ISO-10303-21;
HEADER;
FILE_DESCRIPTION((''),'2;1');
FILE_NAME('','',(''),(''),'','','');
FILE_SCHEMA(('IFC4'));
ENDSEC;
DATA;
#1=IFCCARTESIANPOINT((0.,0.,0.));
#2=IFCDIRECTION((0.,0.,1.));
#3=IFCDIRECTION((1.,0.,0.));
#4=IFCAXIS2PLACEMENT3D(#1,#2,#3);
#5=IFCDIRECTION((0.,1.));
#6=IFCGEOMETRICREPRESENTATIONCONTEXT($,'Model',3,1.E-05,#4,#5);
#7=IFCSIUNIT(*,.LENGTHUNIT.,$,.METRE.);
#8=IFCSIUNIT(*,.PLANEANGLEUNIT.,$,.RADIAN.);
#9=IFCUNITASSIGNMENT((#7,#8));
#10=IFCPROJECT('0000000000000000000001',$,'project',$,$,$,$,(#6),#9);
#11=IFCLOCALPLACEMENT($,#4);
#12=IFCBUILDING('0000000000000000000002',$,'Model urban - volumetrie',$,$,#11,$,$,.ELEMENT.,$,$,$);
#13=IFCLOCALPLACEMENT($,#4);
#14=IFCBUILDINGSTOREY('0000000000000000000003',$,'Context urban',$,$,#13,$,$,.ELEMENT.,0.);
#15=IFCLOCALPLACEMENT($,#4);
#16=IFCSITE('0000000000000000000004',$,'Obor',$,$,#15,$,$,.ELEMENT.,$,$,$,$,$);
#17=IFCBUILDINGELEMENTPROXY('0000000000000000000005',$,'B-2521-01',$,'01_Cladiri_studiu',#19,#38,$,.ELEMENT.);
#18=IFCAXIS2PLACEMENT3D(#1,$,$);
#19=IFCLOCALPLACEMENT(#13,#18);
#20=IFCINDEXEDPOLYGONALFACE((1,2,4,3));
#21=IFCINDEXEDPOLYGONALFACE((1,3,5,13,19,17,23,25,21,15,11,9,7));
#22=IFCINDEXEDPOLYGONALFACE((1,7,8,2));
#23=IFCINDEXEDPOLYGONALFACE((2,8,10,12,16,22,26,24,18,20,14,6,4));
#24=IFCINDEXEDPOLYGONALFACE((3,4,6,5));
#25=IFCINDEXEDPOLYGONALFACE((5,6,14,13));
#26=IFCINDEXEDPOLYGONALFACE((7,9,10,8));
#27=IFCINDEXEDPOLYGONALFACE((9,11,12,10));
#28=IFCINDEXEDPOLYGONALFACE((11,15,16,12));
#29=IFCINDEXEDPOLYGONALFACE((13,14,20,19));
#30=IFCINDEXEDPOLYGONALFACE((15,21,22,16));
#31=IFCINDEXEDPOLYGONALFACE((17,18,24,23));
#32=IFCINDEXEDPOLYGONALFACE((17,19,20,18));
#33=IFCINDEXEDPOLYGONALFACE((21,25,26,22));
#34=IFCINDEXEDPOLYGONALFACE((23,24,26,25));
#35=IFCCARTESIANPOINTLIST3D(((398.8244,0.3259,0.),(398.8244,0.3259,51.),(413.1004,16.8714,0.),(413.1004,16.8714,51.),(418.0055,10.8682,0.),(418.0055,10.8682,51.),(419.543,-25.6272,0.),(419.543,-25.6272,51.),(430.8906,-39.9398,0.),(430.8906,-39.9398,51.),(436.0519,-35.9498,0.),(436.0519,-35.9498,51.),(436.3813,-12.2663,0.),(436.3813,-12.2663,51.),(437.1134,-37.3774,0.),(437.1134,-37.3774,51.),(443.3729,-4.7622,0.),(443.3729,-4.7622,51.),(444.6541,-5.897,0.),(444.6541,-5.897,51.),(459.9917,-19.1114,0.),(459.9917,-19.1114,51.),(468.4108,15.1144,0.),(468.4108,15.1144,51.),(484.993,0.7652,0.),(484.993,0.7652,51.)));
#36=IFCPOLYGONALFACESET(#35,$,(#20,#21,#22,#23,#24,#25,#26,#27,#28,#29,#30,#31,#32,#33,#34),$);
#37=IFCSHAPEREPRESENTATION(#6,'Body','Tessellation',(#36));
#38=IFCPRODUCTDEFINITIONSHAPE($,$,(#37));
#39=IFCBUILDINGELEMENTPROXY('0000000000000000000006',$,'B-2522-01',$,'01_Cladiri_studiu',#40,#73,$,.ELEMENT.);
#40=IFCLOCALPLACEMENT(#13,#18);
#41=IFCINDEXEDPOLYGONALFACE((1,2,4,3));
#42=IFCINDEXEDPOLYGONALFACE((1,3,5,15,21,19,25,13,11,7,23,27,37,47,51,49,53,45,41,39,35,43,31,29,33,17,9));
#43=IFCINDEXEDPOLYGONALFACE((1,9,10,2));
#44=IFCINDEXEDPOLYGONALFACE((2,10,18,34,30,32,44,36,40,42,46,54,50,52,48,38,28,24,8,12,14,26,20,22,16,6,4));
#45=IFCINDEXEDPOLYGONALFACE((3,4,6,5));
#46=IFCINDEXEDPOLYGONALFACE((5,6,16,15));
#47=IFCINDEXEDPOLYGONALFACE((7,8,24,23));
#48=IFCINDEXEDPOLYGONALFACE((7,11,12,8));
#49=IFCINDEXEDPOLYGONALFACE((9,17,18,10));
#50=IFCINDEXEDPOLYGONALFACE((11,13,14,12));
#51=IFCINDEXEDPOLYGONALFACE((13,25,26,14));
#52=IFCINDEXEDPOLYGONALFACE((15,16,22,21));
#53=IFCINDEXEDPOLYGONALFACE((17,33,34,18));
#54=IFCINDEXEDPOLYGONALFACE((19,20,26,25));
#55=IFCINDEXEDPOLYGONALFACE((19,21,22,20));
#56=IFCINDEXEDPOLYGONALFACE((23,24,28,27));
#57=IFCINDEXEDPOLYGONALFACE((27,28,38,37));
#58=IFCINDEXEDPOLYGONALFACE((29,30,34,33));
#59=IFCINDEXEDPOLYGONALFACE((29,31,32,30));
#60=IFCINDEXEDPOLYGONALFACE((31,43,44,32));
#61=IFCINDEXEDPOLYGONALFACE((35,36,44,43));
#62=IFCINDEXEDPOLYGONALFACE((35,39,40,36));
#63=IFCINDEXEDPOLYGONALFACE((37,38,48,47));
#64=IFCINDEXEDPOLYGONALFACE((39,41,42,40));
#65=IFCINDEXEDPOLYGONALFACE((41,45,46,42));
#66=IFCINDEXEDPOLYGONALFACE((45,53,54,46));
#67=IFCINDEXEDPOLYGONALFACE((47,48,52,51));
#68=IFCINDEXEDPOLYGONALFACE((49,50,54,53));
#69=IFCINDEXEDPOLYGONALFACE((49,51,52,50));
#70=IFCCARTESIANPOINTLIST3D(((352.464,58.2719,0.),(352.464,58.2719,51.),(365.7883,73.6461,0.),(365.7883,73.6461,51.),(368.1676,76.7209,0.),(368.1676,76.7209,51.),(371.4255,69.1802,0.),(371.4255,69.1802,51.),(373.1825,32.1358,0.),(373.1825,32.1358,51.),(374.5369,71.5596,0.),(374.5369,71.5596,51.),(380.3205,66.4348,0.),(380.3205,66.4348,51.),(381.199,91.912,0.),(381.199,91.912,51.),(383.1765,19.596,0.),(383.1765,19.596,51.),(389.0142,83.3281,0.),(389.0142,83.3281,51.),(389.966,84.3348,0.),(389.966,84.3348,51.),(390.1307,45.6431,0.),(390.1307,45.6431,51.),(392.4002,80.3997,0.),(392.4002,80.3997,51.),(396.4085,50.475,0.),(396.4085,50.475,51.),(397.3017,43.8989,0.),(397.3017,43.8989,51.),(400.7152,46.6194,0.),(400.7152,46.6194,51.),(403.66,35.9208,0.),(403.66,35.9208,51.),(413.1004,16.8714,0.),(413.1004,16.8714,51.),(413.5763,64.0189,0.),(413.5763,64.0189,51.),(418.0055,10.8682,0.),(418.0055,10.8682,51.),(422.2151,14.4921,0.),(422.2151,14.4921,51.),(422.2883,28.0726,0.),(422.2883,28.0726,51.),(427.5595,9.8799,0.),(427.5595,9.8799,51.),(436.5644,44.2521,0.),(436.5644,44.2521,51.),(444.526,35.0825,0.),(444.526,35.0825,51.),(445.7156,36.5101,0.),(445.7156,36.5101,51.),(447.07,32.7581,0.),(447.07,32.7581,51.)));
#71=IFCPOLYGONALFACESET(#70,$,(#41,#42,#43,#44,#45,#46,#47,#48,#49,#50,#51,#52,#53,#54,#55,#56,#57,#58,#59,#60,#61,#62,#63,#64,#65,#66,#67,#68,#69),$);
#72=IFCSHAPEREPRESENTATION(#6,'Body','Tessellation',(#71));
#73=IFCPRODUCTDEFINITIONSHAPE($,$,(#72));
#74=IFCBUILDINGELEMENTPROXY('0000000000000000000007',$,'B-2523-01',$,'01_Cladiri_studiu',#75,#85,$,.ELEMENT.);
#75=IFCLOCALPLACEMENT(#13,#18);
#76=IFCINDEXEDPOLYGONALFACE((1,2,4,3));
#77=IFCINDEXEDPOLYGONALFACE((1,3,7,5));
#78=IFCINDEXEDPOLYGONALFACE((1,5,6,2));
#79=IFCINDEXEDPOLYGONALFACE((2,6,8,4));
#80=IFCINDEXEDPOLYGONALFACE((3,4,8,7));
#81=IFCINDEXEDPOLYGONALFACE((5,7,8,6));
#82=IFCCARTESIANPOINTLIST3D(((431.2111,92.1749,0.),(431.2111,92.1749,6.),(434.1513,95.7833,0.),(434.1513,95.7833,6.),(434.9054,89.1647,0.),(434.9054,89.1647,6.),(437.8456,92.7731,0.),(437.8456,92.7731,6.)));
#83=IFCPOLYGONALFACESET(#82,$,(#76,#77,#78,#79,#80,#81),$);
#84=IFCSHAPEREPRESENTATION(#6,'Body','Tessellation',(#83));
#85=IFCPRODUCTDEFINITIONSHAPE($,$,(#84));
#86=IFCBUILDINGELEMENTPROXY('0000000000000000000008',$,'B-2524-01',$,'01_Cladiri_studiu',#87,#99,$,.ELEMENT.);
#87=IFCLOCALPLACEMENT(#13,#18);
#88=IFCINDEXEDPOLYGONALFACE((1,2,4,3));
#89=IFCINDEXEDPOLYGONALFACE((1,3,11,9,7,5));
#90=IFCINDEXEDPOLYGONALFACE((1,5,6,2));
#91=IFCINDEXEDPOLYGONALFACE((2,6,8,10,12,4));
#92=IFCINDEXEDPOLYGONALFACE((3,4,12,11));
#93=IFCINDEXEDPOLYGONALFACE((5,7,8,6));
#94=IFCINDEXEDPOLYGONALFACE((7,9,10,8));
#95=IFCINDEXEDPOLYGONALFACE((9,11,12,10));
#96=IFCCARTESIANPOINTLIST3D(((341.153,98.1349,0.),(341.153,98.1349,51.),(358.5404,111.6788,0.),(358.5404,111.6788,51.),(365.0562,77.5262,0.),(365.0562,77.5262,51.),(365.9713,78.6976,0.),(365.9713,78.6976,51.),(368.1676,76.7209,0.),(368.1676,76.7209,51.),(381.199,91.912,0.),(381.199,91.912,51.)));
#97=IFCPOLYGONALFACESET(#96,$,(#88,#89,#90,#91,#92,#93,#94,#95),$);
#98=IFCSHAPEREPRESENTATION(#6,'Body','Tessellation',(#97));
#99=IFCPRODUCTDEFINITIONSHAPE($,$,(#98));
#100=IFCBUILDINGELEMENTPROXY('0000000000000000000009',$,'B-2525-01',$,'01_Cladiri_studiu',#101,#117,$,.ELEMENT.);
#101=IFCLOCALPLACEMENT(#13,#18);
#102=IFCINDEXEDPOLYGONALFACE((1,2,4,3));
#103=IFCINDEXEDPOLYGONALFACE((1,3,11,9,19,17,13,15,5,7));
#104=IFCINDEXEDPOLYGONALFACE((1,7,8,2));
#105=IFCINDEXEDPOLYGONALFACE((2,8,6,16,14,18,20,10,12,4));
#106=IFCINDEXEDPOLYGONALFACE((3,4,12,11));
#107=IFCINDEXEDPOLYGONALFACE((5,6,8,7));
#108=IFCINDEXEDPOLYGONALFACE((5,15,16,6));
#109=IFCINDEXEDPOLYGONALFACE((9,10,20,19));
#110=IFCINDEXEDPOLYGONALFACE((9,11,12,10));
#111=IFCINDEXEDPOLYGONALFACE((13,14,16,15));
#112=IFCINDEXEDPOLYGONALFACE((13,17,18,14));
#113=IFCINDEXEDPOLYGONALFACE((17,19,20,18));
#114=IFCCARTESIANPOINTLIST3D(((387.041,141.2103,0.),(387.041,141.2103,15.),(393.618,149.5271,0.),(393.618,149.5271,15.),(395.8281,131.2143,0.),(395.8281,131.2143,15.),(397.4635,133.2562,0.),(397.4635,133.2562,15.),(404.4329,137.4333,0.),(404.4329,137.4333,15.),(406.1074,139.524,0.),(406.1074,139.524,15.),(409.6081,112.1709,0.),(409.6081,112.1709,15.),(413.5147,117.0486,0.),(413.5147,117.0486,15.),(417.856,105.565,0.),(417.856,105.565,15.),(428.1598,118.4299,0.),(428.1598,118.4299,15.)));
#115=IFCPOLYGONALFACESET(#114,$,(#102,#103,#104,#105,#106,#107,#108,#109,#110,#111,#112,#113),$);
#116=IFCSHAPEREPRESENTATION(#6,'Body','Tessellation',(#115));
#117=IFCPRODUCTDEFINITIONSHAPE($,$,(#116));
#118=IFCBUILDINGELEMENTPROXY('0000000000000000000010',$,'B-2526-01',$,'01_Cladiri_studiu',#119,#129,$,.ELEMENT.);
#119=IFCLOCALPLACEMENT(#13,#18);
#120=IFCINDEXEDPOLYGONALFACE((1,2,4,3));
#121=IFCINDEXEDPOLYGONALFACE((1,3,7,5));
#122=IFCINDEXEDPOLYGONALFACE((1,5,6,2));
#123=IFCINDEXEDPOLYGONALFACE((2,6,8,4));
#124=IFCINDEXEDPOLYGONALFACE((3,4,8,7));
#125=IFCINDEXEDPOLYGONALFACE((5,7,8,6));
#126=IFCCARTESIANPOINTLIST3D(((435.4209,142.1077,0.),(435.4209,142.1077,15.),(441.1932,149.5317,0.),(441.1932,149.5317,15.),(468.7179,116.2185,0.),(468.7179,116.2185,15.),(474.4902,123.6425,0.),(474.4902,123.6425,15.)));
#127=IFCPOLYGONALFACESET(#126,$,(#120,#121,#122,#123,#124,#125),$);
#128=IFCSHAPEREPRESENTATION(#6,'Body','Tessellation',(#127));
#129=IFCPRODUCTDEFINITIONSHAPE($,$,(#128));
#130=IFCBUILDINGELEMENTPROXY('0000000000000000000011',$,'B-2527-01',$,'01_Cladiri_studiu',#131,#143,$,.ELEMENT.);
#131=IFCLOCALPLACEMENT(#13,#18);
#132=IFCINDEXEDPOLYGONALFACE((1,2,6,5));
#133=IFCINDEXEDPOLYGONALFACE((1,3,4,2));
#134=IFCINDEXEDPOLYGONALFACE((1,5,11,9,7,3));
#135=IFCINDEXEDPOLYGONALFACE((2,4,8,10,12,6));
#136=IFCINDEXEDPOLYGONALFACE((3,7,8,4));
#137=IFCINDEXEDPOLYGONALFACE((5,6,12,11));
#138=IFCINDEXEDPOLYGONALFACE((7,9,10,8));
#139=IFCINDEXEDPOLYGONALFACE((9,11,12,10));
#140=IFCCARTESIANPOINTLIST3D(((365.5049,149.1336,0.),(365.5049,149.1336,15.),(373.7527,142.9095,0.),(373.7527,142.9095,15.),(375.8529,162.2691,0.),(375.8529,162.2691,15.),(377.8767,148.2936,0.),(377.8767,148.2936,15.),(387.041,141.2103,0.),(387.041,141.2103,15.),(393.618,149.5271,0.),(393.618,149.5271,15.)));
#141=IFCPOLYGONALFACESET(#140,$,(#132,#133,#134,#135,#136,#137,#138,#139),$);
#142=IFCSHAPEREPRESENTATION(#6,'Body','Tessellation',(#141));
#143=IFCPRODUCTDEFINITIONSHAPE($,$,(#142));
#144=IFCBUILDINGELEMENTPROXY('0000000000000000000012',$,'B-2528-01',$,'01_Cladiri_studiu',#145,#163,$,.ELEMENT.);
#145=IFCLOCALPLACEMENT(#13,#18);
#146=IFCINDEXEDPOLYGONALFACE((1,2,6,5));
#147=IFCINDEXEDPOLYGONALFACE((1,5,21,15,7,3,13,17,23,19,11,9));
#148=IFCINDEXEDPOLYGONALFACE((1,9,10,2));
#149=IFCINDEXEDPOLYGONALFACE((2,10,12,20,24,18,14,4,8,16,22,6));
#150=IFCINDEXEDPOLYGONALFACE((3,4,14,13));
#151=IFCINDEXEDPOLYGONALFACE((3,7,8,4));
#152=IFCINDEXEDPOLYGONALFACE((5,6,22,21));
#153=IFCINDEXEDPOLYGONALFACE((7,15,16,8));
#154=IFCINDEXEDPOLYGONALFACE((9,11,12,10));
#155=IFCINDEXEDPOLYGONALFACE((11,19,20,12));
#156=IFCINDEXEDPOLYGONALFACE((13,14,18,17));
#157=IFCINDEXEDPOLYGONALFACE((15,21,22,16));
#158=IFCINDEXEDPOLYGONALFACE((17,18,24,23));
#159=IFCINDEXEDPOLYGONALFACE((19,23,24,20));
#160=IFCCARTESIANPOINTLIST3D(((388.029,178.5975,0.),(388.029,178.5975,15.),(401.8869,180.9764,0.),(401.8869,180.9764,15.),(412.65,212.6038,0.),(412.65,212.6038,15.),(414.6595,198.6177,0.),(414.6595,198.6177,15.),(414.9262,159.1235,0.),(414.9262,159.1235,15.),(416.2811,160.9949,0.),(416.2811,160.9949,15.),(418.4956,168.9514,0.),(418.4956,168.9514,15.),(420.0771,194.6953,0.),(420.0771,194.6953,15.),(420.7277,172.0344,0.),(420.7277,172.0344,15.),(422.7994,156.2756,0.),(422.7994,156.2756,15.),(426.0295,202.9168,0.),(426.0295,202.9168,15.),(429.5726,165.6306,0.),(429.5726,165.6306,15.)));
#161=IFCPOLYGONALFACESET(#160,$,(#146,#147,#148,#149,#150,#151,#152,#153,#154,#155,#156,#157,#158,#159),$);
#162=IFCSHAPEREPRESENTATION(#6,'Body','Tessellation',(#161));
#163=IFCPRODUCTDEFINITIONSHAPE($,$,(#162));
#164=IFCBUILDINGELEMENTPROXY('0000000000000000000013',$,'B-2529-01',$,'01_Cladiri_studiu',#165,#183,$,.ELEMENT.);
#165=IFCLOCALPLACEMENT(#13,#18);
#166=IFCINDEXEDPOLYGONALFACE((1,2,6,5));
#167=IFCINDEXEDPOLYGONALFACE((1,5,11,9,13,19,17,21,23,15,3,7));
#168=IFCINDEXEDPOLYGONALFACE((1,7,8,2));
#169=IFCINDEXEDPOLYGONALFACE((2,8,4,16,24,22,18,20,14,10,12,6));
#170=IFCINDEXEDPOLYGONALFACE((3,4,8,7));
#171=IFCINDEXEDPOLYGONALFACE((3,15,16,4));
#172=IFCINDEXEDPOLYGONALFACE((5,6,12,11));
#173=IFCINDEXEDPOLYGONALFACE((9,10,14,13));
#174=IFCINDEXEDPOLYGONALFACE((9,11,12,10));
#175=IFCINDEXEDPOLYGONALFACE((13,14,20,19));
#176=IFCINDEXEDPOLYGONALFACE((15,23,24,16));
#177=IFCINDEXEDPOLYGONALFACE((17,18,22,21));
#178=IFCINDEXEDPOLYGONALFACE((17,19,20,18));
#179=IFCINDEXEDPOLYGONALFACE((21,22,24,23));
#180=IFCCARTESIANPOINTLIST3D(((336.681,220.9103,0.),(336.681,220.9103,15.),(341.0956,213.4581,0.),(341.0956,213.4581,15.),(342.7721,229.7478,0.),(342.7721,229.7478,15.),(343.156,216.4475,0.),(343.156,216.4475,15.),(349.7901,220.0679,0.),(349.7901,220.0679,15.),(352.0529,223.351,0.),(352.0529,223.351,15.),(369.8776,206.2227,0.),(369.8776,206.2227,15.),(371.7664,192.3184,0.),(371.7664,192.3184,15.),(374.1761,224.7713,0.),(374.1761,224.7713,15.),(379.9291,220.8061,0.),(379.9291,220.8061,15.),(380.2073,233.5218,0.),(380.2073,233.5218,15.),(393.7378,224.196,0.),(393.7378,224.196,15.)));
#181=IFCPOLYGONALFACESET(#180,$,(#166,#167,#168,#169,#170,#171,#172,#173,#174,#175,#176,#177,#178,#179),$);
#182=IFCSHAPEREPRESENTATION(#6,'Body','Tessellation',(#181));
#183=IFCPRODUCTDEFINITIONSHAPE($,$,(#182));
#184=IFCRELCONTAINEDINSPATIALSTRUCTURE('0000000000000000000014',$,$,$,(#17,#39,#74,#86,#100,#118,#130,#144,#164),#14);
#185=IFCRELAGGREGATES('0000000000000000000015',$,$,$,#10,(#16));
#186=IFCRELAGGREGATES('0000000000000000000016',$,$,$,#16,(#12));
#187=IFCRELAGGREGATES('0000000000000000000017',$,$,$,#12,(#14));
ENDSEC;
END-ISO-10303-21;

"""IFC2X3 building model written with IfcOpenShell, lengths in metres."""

from ifc_helpers import new_model, si_unit, direction, origin_with_axes, place, context, project, spatial, polyline, outline, extrude, element, save


model = new_model("IFC2X3")

# Units and contexts
model_context = context("Model", 3, precision=1e-05, world=origin_with_axes(), true_north=direction((0.0, 1.0)))
ifc_project = project(units=[si_unit("LENGTHUNIT", "METRE"), si_unit("PLANEANGLEUNIT", "RADIAN")], contexts=[model_context])

# Site, building, storey
site_placement = place(None, origin_with_axes())
site = spatial("IfcSite", under=ifc_project, at=site_placement, Name="Obor", CompositionType="ELEMENT")
building_placement = place(None, origin_with_axes())
building = spatial("IfcBuilding", under=site, at=building_placement, Name="Model urban - volumetrie", CompositionType="ELEMENT")
storey_placement = place(None, origin_with_axes())
storey = spatial("IfcBuildingStorey", under=building, at=storey_placement, Name="Context urban", CompositionType="ELEMENT", Elevation=0.0)

# Building element proxies
proxy_1_placement = place(None, origin_with_axes())
element("IfcBuildingElementProxy", 1, at=proxy_1_placement, inside=storey, Name="B-2521-01", ObjectType="01_Cladiri_studiu", CompositionType="ELEMENT", context=model_context, shape_type="SweptSolid", body=[
    extrude(outline(polyline([(443.3729, -4.7622), (444.6541, -5.897), (436.3813, -12.2663), (418.0055, 10.8682), (413.1004, 16.8714), (398.8244, 0.3259), (419.543, -25.6272), (430.8906, -39.9398), (436.0519, -35.9498), (437.1134, -37.3774), (459.9917, -19.1114), (484.993, 0.7652), (468.4108, 15.1144), (443.3729, -4.7622)])), origin_with_axes(), (0.0, 0.0, 1.0), 51.0),
])
proxy_2_placement = place(None, origin_with_axes())
element("IfcBuildingElementProxy", 2, at=proxy_2_placement, inside=storey, Name="B-2522-01", ObjectType="01_Cladiri_studiu", CompositionType="ELEMENT", context=model_context, shape_type="SweptSolid", body=[
    extrude(outline(polyline([(365.7883, 73.6461), (352.464, 58.2719), (373.1825, 32.1358), (383.1765, 19.596), (403.66, 35.9208), (397.3017, 43.8989), (400.7152, 46.6194), (422.2883, 28.0726), (413.1004, 16.8714), (418.0055, 10.8682), (422.2151, 14.4921), (427.5595, 9.8799), (447.07, 32.7581), (444.526, 35.0825), (445.7156, 36.5101), (436.5644, 44.2521), (413.5763, 64.0189), (396.4085, 50.475), (390.1307, 45.6431), (371.4255, 69.1802), (374.5369, 71.5596), (380.3205, 66.4348), (392.4002, 80.3997), (389.0142, 83.3281), (389.966, 84.3348), (381.199, 91.912), (368.1676, 76.7209), (365.7883, 73.6461)])), origin_with_axes(), (0.0, 0.0, 1.0), 51.0),
])
proxy_3_placement = place(None, origin_with_axes())
element("IfcBuildingElementProxy", 3, at=proxy_3_placement, inside=storey, Name="B-2523-01", ObjectType="01_Cladiri_studiu", CompositionType="ELEMENT", context=model_context, shape_type="SweptSolid", body=[
    extrude(outline(polyline([(437.8456, 92.7731), (434.1513, 95.7833), (431.2111, 92.1749), (434.9054, 89.1647), (437.8456, 92.7731)])), origin_with_axes(), (0.0, 0.0, 1.0), 6.0),
])
proxy_4_placement = place(None, origin_with_axes())
element("IfcBuildingElementProxy", 4, at=proxy_4_placement, inside=storey, Name="B-2524-01", ObjectType="01_Cladiri_studiu", CompositionType="ELEMENT", context=model_context, shape_type="SweptSolid", body=[
    extrude(outline(polyline([(365.9713, 78.6976), (368.1676, 76.7209), (381.199, 91.912), (358.5404, 111.6788), (341.153, 98.1349), (365.0562, 77.5262), (365.9713, 78.6976)])), origin_with_axes(), (0.0, 0.0, 1.0), 51.0),
])
proxy_5_placement = place(None, origin_with_axes())
element("IfcBuildingElementProxy", 5, at=proxy_5_placement, inside=storey, Name="B-2525-01", ObjectType="01_Cladiri_studiu", CompositionType="ELEMENT", context=model_context, shape_type="SweptSolid", body=[
    extrude(outline(polyline([(395.8281, 131.2143), (413.5147, 117.0486), (409.6081, 112.1709), (417.856, 105.565), (428.1598, 118.4299), (404.4329, 137.4333), (406.1074, 139.524), (393.618, 149.5271), (387.041, 141.2103), (397.4635, 133.2562), (395.8281, 131.2143)])), origin_with_axes(), (0.0, 0.0, 1.0), 15.0),
])
proxy_6_placement = place(None, origin_with_axes())
element("IfcBuildingElementProxy", 6, at=proxy_6_placement, inside=storey, Name="B-2526-01", ObjectType="01_Cladiri_studiu", CompositionType="ELEMENT", context=model_context, shape_type="SweptSolid", body=[
    extrude(outline(polyline([(474.4902, 123.6425), (441.1932, 149.5317), (435.4209, 142.1077), (468.7179, 116.2185), (474.4902, 123.6425)])), origin_with_axes(), (0.0, 0.0, 1.0), 15.0),
])
proxy_7_placement = place(None, origin_with_axes())
element("IfcBuildingElementProxy", 7, at=proxy_7_placement, inside=storey, Name="B-2527-01", ObjectType="01_Cladiri_studiu", CompositionType="ELEMENT", context=model_context, shape_type="SweptSolid", body=[
    extrude(outline(polyline([(365.5049, 149.1336), (373.7527, 142.9095), (377.8767, 148.2936), (387.041, 141.2103), (393.618, 149.5271), (375.8529, 162.2691), (365.5049, 149.1336)])), origin_with_axes(), (0.0, 0.0, 1.0), 15.0),
])
proxy_8_placement = place(None, origin_with_axes())
element("IfcBuildingElementProxy", 8, at=proxy_8_placement, inside=storey, Name="B-2528-01", ObjectType="01_Cladiri_studiu", CompositionType="ELEMENT", context=model_context, shape_type="SweptSolid", body=[
    extrude(outline(polyline([(388.029, 178.5975), (414.9262, 159.1235), (416.2811, 160.9949), (422.7994, 156.2756), (429.5726, 165.6306), (420.7277, 172.0344), (418.4956, 168.9514), (401.8869, 180.9764), (414.6595, 198.6177), (420.0771, 194.6953), (426.0295, 202.9168), (412.65, 212.6038), (388.029, 178.5975)])), origin_with_axes(), (0.0, 0.0, 1.0), 15.0),
])
proxy_9_placement = place(None, origin_with_axes())
element("IfcBuildingElementProxy", 9, at=proxy_9_placement, inside=storey, Name="B-2529-01", ObjectType="01_Cladiri_studiu", CompositionType="ELEMENT", context=model_context, shape_type="SweptSolid", body=[
    extrude(outline(polyline([(374.1761, 224.7713), (379.9291, 220.8061), (369.8776, 206.2227), (349.7901, 220.0679), (352.0529, 223.351), (342.7721, 229.7478), (336.681, 220.9103), (343.156, 216.4475), (341.0956, 213.4581), (371.7664, 192.3184), (393.7378, 224.196), (380.2073, 233.5218), (374.1761, 224.7713)])), origin_with_axes(), (0.0, 0.0, 1.0), 15.0),
])

save(model, "model.ifc")
